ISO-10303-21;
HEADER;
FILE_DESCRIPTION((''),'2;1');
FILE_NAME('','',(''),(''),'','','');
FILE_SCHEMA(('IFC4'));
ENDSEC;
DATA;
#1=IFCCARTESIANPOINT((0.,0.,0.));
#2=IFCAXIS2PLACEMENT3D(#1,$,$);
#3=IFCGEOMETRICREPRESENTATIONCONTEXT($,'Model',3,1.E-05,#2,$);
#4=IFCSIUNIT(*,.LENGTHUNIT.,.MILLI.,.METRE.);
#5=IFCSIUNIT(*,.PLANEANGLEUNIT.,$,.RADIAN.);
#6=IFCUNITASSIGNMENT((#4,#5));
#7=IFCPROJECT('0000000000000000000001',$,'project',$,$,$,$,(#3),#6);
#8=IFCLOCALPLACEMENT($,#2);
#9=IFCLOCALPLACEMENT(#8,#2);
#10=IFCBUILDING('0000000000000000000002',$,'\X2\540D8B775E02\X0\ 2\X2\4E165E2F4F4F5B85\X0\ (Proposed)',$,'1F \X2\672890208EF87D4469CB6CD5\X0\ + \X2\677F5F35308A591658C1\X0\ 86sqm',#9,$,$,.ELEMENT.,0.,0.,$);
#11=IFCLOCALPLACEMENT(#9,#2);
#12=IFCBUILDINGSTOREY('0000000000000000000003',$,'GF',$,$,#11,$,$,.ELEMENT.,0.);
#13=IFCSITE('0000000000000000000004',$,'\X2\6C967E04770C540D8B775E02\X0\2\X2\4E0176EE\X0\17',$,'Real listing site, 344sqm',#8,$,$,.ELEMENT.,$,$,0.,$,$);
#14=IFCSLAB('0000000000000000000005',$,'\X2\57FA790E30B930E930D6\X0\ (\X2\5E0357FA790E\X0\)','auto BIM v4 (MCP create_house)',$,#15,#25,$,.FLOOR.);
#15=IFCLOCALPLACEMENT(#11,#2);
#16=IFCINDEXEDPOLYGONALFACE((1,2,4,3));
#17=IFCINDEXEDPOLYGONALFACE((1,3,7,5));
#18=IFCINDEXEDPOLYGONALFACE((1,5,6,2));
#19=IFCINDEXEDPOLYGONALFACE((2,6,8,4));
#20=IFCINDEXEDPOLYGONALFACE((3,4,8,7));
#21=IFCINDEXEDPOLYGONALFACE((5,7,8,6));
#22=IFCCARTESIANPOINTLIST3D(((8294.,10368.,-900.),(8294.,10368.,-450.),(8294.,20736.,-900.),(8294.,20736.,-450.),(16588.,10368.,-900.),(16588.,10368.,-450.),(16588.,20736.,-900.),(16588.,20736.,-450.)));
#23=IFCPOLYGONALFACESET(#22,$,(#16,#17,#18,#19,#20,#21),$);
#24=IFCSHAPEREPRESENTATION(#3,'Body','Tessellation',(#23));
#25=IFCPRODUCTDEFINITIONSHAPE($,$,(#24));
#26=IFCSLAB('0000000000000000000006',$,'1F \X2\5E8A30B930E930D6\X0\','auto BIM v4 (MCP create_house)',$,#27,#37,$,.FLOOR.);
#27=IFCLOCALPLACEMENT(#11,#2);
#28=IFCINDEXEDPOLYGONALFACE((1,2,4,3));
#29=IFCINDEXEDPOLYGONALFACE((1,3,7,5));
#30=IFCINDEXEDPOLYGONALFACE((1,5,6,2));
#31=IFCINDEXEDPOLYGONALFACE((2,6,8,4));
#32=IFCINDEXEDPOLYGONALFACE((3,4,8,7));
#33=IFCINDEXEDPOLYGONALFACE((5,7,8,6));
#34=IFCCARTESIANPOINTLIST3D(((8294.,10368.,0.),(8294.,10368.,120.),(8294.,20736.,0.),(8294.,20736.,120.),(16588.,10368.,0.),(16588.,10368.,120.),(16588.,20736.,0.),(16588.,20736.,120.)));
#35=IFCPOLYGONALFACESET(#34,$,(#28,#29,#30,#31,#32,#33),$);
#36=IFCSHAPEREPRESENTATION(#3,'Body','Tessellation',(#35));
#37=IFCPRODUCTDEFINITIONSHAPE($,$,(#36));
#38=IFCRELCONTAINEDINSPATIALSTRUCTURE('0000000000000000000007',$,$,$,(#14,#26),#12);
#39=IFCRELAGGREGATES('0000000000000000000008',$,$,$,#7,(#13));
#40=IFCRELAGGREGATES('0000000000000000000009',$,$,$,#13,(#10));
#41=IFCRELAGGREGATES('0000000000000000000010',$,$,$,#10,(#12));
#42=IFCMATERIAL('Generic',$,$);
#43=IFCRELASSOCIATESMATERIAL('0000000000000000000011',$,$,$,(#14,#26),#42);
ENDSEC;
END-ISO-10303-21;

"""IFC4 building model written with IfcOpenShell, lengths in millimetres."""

from ifc_helpers import new_model, si_unit, frame, frame_2d, origin, place, context, project, spatial, rectangle, extrude, material, element, save


model = new_model("IFC4")

# Units and contexts
model_context = context("Model", 3, precision=1e-05, world=origin())
ifc_project = project(units=[si_unit("LENGTHUNIT", "METRE", prefix="MILLI"), si_unit("PLANEANGLEUNIT", "RADIAN")], contexts=[model_context])

# Site, building, storey
site_placement = place(None, origin())
site = spatial("IfcSite", under=ifc_project, at=site_placement, Name="沖縄県名護市2丁目17", ObjectType="Real listing site, 344sqm", CompositionType="ELEMENT", RefElevation=0.0)
building_placement = place(site_placement, origin())
building = spatial("IfcBuilding", under=site, at=building_placement, Name="名護市 2世帯住宅 (Proposed)", ObjectType="1F 木造軸組構法 + 板張り外壁 86sqm", CompositionType="ELEMENT", ElevationOfRefHeight=0.0, ElevationOfTerrain=0.0)
storey_placement = place(building_placement, origin())
storey = spatial("IfcBuildingStorey", under=building, at=storey_placement, Name="GF", CompositionType="ELEMENT", Elevation=0.0)

# Slabs
ifc_material = material(Name="Generic")
slab_1_placement = place(storey_placement, frame((4147.0, 5184.0, -450.0)))
element("IfcSlab", 1, at=slab_1_placement, inside=storey, material=ifc_material, Name="基礎スラブ (布基礎)", Description="auto BIM v4 (MCP create_house)", PredefinedType="FLOOR", context=model_context, shape_type="SweptSolid", body=[
    extrude(rectangle(XDim=8294.0, YDim=10368.0, at=frame_2d((4147.0, 5184.0))), frame((4147.0, 5184.0, -450.0)), (0.0, 0.0, 1.0), 450.0),
])
slab_2_placement = place(storey_placement, frame((4147.0, 5184.0, 0.0)))
element("IfcSlab", 2, at=slab_2_placement, inside=storey, material=ifc_material, Name="1F 床スラブ", Description="auto BIM v4 (MCP create_house)", PredefinedType="FLOOR", context=model_context, shape_type="SweptSolid", body=[
    extrude(rectangle(XDim=8294.0, YDim=10368.0, at=frame_2d((4147.0, 5184.0))), frame((4147.0, 5184.0, 0.0)), (0.0, 0.0, 1.0), 120.0),
])

save(model, "model.ifc")
